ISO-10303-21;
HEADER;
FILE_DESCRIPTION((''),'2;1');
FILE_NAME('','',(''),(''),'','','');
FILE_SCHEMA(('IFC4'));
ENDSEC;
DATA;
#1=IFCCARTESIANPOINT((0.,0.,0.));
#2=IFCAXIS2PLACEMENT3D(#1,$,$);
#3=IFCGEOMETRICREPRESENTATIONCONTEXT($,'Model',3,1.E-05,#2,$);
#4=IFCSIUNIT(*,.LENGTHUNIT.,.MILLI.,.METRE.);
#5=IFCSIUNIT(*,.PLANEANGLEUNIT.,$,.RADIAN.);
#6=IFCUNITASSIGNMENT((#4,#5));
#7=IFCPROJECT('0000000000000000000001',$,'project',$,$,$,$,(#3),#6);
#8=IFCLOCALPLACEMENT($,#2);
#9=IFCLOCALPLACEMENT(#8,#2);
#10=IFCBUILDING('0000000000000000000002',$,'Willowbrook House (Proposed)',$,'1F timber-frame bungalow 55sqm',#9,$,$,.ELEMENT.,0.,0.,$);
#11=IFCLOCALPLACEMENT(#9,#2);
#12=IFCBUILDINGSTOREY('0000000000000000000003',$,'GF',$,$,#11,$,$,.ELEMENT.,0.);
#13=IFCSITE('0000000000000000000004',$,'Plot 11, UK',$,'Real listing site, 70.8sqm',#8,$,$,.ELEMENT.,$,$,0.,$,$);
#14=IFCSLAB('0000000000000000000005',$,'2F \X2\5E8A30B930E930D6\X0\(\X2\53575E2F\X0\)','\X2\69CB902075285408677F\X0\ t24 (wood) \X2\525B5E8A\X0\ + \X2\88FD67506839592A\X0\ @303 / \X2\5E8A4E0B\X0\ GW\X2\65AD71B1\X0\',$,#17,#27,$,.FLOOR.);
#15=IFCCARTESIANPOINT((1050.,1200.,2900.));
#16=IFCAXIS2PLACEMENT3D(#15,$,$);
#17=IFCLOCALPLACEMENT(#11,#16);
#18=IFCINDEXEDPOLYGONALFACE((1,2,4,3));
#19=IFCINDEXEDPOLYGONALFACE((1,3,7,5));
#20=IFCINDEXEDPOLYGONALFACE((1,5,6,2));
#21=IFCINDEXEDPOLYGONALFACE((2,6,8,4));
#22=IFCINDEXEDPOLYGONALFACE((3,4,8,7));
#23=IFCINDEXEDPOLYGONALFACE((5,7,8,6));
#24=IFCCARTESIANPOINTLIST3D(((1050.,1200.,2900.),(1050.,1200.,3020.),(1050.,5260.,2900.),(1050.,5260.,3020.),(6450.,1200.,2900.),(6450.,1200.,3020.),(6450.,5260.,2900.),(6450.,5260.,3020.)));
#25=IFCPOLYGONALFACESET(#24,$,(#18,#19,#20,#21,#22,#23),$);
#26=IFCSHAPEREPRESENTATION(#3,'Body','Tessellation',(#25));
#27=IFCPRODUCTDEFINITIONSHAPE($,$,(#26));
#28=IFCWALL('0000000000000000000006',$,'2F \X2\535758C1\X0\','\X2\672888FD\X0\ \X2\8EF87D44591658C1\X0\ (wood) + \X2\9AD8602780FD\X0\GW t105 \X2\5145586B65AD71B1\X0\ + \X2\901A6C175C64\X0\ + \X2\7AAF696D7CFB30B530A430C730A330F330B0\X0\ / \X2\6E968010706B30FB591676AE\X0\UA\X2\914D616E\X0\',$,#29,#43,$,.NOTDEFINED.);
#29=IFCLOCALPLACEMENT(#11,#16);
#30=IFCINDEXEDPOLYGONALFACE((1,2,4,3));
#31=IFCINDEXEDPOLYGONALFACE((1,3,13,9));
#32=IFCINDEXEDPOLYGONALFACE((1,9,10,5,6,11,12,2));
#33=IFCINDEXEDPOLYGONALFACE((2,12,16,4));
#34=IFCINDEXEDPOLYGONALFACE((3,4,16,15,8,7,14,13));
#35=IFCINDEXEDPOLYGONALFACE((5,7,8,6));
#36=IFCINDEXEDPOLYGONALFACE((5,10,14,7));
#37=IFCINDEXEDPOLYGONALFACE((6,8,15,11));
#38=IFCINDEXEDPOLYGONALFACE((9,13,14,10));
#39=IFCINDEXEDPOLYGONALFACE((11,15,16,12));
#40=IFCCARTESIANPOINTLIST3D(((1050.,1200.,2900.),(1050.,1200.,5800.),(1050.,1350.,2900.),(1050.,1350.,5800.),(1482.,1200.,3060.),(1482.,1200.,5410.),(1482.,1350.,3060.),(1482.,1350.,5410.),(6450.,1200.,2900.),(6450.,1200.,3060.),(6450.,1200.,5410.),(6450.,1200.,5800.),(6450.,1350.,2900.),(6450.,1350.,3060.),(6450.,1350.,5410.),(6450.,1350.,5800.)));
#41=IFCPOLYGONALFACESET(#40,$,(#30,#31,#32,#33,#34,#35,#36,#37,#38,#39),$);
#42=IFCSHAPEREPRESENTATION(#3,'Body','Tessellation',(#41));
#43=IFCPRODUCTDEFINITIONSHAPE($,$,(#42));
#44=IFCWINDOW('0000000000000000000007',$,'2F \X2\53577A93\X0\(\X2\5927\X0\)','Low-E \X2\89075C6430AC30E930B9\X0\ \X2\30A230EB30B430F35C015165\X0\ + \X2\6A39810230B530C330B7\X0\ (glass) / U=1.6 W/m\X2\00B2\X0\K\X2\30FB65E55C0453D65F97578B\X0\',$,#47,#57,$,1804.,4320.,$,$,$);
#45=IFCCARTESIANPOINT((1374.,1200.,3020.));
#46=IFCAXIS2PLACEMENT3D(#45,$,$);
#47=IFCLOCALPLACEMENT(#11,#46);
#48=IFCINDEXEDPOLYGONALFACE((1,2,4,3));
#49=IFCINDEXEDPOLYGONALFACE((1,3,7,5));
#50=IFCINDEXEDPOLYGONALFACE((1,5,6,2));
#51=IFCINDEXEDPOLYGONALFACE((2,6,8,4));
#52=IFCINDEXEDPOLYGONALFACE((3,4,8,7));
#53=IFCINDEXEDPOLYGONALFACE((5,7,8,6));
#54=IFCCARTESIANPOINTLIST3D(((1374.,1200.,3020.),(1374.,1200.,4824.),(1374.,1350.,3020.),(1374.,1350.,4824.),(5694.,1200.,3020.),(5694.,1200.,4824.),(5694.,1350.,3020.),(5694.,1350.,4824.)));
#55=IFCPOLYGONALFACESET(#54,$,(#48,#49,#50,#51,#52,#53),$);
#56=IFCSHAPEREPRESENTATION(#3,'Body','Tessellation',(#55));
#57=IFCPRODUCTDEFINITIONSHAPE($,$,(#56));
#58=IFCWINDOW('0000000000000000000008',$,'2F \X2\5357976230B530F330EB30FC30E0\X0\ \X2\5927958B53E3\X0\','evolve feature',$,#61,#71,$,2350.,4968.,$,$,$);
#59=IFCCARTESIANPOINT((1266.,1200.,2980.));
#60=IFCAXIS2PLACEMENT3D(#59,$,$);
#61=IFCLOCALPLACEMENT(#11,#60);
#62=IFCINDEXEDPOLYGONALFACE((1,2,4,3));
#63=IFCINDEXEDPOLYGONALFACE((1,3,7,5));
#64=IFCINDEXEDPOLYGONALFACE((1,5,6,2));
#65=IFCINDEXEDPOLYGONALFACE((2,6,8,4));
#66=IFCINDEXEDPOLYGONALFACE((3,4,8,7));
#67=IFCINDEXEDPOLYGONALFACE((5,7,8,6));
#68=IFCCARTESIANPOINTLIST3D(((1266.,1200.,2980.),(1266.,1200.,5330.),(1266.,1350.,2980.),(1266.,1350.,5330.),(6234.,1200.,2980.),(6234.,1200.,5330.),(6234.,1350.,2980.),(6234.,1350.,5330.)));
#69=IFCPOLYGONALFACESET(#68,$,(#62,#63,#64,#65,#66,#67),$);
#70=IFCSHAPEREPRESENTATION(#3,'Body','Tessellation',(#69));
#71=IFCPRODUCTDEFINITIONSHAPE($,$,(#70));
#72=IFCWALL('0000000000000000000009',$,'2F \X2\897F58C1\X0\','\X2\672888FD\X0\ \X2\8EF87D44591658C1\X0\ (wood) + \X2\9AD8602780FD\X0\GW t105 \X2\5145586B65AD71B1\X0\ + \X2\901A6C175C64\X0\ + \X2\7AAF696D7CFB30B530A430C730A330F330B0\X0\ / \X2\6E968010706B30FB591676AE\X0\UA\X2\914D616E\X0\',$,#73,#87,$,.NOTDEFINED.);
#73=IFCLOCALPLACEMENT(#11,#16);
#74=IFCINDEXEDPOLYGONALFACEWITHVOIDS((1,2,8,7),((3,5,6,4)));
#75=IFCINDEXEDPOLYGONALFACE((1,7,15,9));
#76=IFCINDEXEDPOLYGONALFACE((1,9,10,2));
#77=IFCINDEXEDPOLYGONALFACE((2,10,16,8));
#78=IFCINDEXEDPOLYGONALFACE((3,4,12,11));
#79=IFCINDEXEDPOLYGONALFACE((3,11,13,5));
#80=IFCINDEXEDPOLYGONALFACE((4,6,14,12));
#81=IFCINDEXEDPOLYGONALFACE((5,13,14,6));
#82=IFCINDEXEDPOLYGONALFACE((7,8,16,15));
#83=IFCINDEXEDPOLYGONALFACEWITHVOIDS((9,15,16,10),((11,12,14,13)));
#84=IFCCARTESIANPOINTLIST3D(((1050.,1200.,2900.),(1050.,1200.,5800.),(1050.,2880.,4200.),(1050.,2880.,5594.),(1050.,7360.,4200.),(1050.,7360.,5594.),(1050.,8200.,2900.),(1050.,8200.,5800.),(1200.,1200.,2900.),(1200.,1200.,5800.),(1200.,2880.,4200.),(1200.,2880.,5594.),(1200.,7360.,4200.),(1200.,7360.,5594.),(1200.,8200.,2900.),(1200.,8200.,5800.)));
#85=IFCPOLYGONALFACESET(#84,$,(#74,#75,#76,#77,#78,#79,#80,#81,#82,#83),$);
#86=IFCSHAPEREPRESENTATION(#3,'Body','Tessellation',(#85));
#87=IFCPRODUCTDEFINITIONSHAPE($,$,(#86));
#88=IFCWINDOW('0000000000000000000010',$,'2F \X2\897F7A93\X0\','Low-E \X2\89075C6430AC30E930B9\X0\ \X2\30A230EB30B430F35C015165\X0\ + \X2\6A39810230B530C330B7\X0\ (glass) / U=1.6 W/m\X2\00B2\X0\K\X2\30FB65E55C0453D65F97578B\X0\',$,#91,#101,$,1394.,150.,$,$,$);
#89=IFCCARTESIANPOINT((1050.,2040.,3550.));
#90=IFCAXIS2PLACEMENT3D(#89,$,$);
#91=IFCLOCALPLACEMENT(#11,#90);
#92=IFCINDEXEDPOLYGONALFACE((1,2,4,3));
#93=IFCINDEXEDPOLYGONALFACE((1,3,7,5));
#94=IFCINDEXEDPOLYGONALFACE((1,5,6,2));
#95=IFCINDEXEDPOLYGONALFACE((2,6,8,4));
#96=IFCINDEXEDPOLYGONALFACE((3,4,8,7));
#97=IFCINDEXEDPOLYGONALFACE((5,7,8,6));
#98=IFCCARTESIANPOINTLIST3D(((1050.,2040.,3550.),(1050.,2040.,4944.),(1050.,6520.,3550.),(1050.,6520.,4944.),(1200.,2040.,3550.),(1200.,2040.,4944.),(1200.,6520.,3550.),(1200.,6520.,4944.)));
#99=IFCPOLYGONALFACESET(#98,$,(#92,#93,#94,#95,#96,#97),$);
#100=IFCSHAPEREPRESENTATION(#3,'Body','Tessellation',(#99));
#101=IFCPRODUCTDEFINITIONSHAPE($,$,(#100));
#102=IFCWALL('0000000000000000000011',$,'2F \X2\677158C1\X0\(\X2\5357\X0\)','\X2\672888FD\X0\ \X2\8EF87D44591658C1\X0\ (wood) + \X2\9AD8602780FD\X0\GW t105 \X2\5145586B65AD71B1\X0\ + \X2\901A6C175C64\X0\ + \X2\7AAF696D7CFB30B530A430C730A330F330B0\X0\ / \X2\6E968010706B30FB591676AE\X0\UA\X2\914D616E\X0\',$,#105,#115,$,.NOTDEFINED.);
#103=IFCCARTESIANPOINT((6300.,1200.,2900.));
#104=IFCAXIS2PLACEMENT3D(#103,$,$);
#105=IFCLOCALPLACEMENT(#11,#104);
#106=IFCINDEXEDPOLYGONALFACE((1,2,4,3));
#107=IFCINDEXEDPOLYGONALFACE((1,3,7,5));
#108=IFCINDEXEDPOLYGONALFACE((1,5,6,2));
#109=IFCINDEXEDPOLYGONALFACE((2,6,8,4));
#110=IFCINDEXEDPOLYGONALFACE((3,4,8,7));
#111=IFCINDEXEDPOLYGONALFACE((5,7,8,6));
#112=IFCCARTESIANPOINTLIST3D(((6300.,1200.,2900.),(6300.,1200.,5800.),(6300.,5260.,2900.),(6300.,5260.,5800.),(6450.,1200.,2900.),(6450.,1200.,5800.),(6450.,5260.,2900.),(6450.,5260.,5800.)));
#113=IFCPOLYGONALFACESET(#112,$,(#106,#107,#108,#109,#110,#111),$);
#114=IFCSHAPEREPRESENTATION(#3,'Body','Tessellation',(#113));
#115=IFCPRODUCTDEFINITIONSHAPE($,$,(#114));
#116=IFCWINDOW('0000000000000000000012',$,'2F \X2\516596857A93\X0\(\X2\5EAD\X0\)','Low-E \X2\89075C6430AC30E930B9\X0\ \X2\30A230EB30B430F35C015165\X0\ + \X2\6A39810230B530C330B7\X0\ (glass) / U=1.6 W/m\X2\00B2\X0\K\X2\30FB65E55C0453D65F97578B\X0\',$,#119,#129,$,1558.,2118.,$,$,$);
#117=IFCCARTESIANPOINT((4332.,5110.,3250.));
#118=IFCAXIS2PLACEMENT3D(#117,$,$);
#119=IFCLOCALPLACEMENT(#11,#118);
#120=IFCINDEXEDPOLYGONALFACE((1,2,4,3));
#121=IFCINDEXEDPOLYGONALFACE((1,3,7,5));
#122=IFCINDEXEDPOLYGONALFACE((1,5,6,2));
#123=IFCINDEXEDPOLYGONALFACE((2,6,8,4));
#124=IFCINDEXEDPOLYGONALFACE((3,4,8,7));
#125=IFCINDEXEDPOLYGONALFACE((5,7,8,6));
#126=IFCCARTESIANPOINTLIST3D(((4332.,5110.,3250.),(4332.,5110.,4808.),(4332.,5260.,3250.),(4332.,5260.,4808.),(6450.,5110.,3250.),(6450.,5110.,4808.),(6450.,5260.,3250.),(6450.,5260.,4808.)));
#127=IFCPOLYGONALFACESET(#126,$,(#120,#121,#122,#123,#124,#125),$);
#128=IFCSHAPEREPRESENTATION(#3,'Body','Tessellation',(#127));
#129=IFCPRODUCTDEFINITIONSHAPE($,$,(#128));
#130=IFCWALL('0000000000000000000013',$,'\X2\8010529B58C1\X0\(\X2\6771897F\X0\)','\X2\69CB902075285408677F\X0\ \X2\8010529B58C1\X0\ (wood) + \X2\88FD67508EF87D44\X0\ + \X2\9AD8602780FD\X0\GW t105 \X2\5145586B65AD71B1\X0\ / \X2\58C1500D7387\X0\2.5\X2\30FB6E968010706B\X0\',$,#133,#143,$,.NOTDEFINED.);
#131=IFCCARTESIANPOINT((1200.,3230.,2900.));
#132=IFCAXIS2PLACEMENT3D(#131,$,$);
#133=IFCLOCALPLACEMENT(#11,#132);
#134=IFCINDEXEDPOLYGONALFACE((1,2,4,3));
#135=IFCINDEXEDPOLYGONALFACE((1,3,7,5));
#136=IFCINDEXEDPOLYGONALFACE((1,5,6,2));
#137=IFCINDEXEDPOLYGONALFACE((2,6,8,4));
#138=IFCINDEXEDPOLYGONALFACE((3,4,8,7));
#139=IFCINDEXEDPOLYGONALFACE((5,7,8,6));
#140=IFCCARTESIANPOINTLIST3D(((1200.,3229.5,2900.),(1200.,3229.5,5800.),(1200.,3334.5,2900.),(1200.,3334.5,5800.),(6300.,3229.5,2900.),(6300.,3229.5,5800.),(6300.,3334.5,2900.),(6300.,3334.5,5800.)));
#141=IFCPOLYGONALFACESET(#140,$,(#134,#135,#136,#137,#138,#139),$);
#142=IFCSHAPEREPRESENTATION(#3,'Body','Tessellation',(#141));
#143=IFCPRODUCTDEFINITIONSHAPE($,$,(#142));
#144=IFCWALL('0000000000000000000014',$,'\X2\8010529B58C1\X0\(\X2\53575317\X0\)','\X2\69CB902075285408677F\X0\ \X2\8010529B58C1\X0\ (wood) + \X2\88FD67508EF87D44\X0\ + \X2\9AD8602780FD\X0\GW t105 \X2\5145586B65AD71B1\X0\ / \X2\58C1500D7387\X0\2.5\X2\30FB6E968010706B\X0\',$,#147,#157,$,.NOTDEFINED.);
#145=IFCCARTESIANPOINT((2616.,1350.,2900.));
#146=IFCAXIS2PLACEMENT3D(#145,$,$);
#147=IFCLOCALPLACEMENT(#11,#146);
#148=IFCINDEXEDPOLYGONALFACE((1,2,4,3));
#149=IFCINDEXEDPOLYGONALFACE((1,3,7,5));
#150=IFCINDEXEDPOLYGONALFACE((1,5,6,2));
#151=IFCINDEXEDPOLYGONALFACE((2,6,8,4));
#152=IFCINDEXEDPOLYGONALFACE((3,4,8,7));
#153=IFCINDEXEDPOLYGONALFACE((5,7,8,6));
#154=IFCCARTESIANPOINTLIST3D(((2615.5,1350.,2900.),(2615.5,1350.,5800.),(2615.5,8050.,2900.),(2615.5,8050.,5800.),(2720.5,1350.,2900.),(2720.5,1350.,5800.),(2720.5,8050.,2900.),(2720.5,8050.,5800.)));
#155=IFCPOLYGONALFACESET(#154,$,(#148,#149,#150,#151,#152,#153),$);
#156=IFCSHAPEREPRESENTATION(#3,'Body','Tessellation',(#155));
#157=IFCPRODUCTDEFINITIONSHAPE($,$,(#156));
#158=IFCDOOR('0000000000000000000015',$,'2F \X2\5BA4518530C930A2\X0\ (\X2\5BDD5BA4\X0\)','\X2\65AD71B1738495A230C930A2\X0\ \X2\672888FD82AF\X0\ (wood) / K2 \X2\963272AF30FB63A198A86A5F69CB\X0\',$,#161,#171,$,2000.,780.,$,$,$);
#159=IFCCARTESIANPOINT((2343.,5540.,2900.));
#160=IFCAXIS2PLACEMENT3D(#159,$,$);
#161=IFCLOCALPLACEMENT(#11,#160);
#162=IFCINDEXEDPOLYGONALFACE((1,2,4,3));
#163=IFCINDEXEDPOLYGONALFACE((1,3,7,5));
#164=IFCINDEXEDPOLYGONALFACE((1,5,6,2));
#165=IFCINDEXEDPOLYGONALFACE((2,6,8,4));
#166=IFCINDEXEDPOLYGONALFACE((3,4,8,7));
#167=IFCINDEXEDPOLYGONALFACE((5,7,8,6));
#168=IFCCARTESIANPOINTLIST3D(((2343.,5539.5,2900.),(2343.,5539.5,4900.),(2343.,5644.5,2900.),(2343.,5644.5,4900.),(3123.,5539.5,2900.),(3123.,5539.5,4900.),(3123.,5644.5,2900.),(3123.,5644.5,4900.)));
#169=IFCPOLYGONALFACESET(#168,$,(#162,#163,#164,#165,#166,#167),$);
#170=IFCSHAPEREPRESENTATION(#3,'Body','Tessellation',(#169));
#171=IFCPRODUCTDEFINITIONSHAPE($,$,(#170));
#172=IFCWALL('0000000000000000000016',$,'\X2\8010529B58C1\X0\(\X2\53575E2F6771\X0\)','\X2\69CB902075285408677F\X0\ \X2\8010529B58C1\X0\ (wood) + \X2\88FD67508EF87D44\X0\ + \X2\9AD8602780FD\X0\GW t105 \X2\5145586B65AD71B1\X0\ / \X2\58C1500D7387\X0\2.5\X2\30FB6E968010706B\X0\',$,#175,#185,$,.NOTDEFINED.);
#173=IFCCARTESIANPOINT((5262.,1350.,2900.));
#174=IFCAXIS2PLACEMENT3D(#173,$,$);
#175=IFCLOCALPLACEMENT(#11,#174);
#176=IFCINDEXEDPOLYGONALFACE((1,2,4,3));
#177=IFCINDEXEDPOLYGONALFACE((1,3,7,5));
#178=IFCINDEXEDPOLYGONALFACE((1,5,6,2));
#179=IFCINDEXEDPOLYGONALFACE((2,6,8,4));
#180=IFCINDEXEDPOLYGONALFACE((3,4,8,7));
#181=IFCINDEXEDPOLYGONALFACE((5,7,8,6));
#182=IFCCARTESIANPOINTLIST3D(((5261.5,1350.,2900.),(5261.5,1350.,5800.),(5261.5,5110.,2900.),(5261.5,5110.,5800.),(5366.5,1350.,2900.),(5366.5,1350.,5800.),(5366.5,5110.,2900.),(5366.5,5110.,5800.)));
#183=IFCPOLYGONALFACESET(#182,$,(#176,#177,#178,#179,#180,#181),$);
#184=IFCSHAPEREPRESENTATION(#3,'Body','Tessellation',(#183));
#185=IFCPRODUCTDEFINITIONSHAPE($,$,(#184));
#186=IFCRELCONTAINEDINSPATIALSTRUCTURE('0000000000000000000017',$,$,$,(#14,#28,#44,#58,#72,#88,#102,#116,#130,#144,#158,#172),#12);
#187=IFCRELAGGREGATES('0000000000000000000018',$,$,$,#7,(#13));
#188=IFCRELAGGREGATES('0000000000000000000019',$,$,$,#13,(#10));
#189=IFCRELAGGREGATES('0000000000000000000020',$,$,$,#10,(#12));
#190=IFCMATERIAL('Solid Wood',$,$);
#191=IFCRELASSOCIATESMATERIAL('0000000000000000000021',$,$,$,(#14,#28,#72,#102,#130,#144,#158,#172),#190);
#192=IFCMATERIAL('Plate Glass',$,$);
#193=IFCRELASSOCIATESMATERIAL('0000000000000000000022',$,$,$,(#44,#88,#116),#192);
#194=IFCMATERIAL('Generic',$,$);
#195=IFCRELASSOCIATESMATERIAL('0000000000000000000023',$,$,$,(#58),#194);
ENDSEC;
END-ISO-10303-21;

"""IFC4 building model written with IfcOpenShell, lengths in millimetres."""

from ifc_helpers import new_model, si_unit, frame, frame_2d, origin, place, context, project, spatial, rectangle, extrude, material, element, fill, save


model = new_model("IFC4")

# Units and contexts
model_context = context("Model", 3, precision=1e-05, world=origin())
ifc_project = project(units=[si_unit("LENGTHUNIT", "METRE", prefix="MILLI"), si_unit("PLANEANGLEUNIT", "RADIAN")], contexts=[model_context])

# Site, building, storey
site_placement = place(None, origin())
site = spatial("IfcSite", under=ifc_project, at=site_placement, Name="Plot 11, UK", ObjectType="Real listing site, 70.8sqm", CompositionType="ELEMENT", RefElevation=0.0)
building_placement = place(site_placement, origin())
building = spatial("IfcBuilding", under=site, at=building_placement, Name="Willowbrook House (Proposed)", ObjectType="1F timber-frame bungalow 55sqm", CompositionType="ELEMENT", ElevationOfRefHeight=0.0, ElevationOfTerrain=0.0)
storey_placement = place(building_placement, origin())
storey = spatial("IfcBuildingStorey", under=building, at=storey_placement, Name="GF", CompositionType="ELEMENT", Elevation=0.0)

# Slab
ifc_material_1 = material(Name="Solid Wood")
slab_placement = place(storey_placement, frame((1050.0, 1200.0, 2900.0)))
element("IfcSlab", 1, at=slab_placement, inside=storey, material=ifc_material_1, Name="2F 床スラブ(南帯)", Description="構造用合板 t24 (wood) 剛床 + 製材根太 @303 / 床下 GW断熱", PredefinedType="FLOOR", context=model_context, shape_type="SweptSolid", body=[
    extrude(rectangle(XDim=5400.0, YDim=4060.0, at=frame_2d((2700.0, 2030.0))), frame((1050.0, 1200.0, 2900.0)), (0.0, 0.0, 1.0), 120.0),
])

# Wall, openings, windows
wall_1_placement = place(storey_placement, frame((1050.0, 1200.0, 2900.0)))
wall_1 = element("IfcWall", 2, at=wall_1_placement, inside=storey, material=ifc_material_1, Name="2F 南壁", Description="木製 軸組外壁 (wood) + 高性能GW t105 充填断熱 + 通気層 + 窯業系サイディング / 準耐火・外皮UA配慮", PredefinedType="NOTDEFINED", context=model_context, shape_type="SweptSolid", body=[
    extrude(rectangle(XDim=5400.0, YDim=150.0, at=frame_2d((2700.0, 75.0))), frame((1050.0, 1200.0, 2900.0)), (0.0, 0.0, 1.0), 2900.0),
])
opening_1_placement = place(storey_placement, frame((1374.0, 1200.0, 3020.0)))
opening_1 = element("IfcOpeningElement", 3, at=opening_1_placement, cuts=wall_1, PredefinedType="NOTDEFINED", context=model_context, shape_type="SweptSolid", body=[
    extrude(rectangle(XDim=4320.0, YDim=150.0, at=frame_2d((2160.0, 75.0))), frame((1374.0, 1200.0, 3020.0)), (0.0, 0.0, 1.0), 1804.0),
])
opening_2_placement = place(storey_placement, frame((1266.0, 1200.0, 2980.0)))
opening_2 = element("IfcOpeningElement", 4, at=opening_2_placement, cuts=wall_1, PredefinedType="NOTDEFINED", context=model_context, shape_type="SweptSolid", body=[
    extrude(rectangle(XDim=4968.0, YDim=150.0, at=frame_2d((2484.0, 75.0))), frame((1266.0, 1200.0, 2980.0)), (0.0, 0.0, 1.0), 2350.0),
])
ifc_material_2 = material(Name="Plate Glass")
window_1_placement = place(storey_placement, frame((1374.0, 1200.0, 3020.0)))
window_1 = element("IfcWindow", 5, at=window_1_placement, inside=storey, material=ifc_material_2, Name="2F 南窓(大)", Description="Low-E 複層ガラス アルゴン封入 + 樹脂サッシ (glass) / U=1.6 W/m²K・日射取得型", OverallHeight=1804.0, OverallWidth=4320.0, context=model_context, shape_type="SweptSolid", body=[
    extrude(rectangle(XDim=4320.0, YDim=150.0, at=frame_2d((2160.0, 75.0))), frame((1374.0, 1200.0, 3020.0)), (0.0, 0.0, 1.0), 1804.0),
])
fill(opening_1, window_1)
ifc_material_3 = material(Name="Generic")
window_2_placement = place(storey_placement, frame((1266.0, 1200.0, 2980.0)))
window_2 = element("IfcWindow", 6, at=window_2_placement, inside=storey, material=ifc_material_3, Name="2F 南面サンルーム 大開口", Description="evolve feature", OverallHeight=2350.0, OverallWidth=4968.0, context=model_context, shape_type="SweptSolid", body=[
    extrude(rectangle(XDim=4968.0, YDim=150.0, at=frame_2d((2484.0, 75.0))), frame((1266.0, 1200.0, 2980.0)), (0.0, 0.0, 1.0), 2350.0),
])
fill(opening_2, window_2)

# Walls, openings, windows
wall_2_placement = place(storey_placement, frame((1050.0, 1200.0, 2900.0)))
wall_2 = element("IfcWall", 7, at=wall_2_placement, inside=storey, material=ifc_material_1, Name="2F 西壁", Description="木製 軸組外壁 (wood) + 高性能GW t105 充填断熱 + 通気層 + 窯業系サイディング / 準耐火・外皮UA配慮", PredefinedType="NOTDEFINED", context=model_context, shape_type="SweptSolid", body=[
    extrude(rectangle(XDim=150.0, YDim=7000.0, at=frame_2d((75.0, 3500.0))), frame((1050.0, 1200.0, 2900.0)), (0.0, 0.0, 1.0), 2900.0),
])
opening_3_placement = place(storey_placement, frame((1050.0, 2040.0, 3550.0)))
opening_3 = element("IfcOpeningElement", 8, at=opening_3_placement, cuts=wall_2, PredefinedType="NOTDEFINED", context=model_context, shape_type="SweptSolid", body=[
    extrude(rectangle(XDim=150.0, YDim=4480.0, at=frame_2d((75.0, 2240.0))), frame((1050.0, 2040.0, 3550.0)), (0.0, 0.0, 1.0), 1394.0),
])
window_3_placement = place(storey_placement, frame((1050.0, 2040.0, 3550.0)))
window_3 = element("IfcWindow", 9, at=window_3_placement, inside=storey, material=ifc_material_2, Name="2F 西窓", Description="Low-E 複層ガラス アルゴン封入 + 樹脂サッシ (glass) / U=1.6 W/m²K・日射取得型", OverallHeight=1394.0, OverallWidth=150.0, context=model_context, shape_type="SweptSolid", body=[
    extrude(rectangle(XDim=150.0, YDim=4480.0, at=frame_2d((75.0, 2240.0))), frame((1050.0, 2040.0, 3550.0)), (0.0, 0.0, 1.0), 1394.0),
])
fill(opening_3, window_3)
wall_3_placement = place(storey_placement, frame((6300.0, 1200.0, 2900.0)))
wall_3 = element("IfcWall", 10, at=wall_3_placement, inside=storey, material=ifc_material_1, Name="2F 東壁(南)", Description="木製 軸組外壁 (wood) + 高性能GW t105 充填断熱 + 通気層 + 窯業系サイディング / 準耐火・外皮UA配慮", PredefinedType="NOTDEFINED", context=model_context, shape_type="SweptSolid", body=[
    extrude(rectangle(XDim=150.0, YDim=4060.0, at=frame_2d((75.0, 2030.0))), frame((6300.0, 1200.0, 2900.0)), (0.0, 0.0, 1.0), 2900.0),
])
opening_4_placement = place(storey_placement, frame((4332.0, 5110.0, 3250.0)))
opening_4 = element("IfcOpeningElement", 11, at=opening_4_placement, cuts=wall_3, PredefinedType="NOTDEFINED", context=model_context, shape_type="SweptSolid", body=[
    extrude(rectangle(XDim=2118.0, YDim=150.0, at=frame_2d((1059.0, 75.0))), frame((4332.0, 5110.0, 3250.0)), (0.0, 0.0, 1.0), 1558.0),
])
window_4_placement = place(storey_placement, frame((4332.0, 5110.0, 3250.0)))
window_4 = element("IfcWindow", 12, at=window_4_placement, inside=storey, material=ifc_material_2, Name="2F 入隅窓(庭)", Description="Low-E 複層ガラス アルゴン封入 + 樹脂サッシ (glass) / U=1.6 W/m²K・日射取得型", OverallHeight=1558.0, OverallWidth=2118.0, context=model_context, shape_type="SweptSolid", body=[
    extrude(rectangle(XDim=2118.0, YDim=150.0, at=frame_2d((1059.0, 75.0))), frame((4332.0, 5110.0, 3250.0)), (0.0, 0.0, 1.0), 1558.0),
])
fill(opening_4, window_4)

# Wall
wall_4_placement = place(storey_placement, frame((1200.0, 3230.0, 2900.0)))
element("IfcWall", 13, at=wall_4_placement, inside=storey, material=ifc_material_1, Name="耐力壁(東西)", Description="構造用合板 耐力壁 (wood) + 製材軸組 + 高性能GW t105 充填断熱 / 壁倍率2.5・準耐火", PredefinedType="NOTDEFINED", context=model_context, shape_type="SweptSolid", body=[
    extrude(rectangle(XDim=5100.0, YDim=105.0, at=frame_2d((2550.0, 52.0))), frame((1200.0, 3230.0, 2900.0)), (0.0, 0.0, 1.0), 2900.0),
])

# Wall, opening, door
wall_5_placement = place(storey_placement, frame((2616.0, 1350.0, 2900.0)))
wall_5 = element("IfcWall", 14, at=wall_5_placement, inside=storey, material=ifc_material_1, Name="耐力壁(南北)", Description="構造用合板 耐力壁 (wood) + 製材軸組 + 高性能GW t105 充填断熱 / 壁倍率2.5・準耐火", PredefinedType="NOTDEFINED", context=model_context, shape_type="SweptSolid", body=[
    extrude(rectangle(XDim=105.0, YDim=6700.0, at=frame_2d((52.0, 3350.0))), frame((2616.0, 1350.0, 2900.0)), (0.0, 0.0, 1.0), 2900.0),
])
opening_5_placement = place(storey_placement, frame((2343.0, 5540.0, 2900.0)))
opening_5 = element("IfcOpeningElement", 15, at=opening_5_placement, cuts=wall_5, PredefinedType="NOTDEFINED", context=model_context, shape_type="SweptSolid", body=[
    extrude(rectangle(XDim=780.0, YDim=105.0, at=frame_2d((390.0, 52.0))), frame((2343.0, 5540.0, 2900.0)), (0.0, 0.0, 1.0), 2000.0),
])
door_placement = place(storey_placement, frame((2343.0, 5540.0, 2900.0)))
door = element("IfcDoor", 16, at=door_placement, inside=storey, material=ifc_material_1, Name="2F 室内ドア (寝室)", Description="断熱玄関ドア 木製芯 (wood) / K2 防犯・採風機構", OverallHeight=2000.0, OverallWidth=780.0, context=model_context, shape_type="SweptSolid", body=[
    extrude(rectangle(XDim=780.0, YDim=105.0, at=frame_2d((390.0, 52.0))), frame((2343.0, 5540.0, 2900.0)), (0.0, 0.0, 1.0), 2000.0),
])
fill(opening_5, door)

# Wall
wall_6_placement = place(storey_placement, frame((5262.0, 1350.0, 2900.0)))
element("IfcWall", 17, at=wall_6_placement, inside=storey, material=ifc_material_1, Name="耐力壁(南帯東)", Description="構造用合板 耐力壁 (wood) + 製材軸組 + 高性能GW t105 充填断熱 / 壁倍率2.5・準耐火", PredefinedType="NOTDEFINED", context=model_context, shape_type="SweptSolid", body=[
    extrude(rectangle(XDim=105.0, YDim=3760.0, at=frame_2d((52.0, 1880.0))), frame((5262.0, 1350.0, 2900.0)), (0.0, 0.0, 1.0), 2900.0),
])

save(model, "model.ifc")
